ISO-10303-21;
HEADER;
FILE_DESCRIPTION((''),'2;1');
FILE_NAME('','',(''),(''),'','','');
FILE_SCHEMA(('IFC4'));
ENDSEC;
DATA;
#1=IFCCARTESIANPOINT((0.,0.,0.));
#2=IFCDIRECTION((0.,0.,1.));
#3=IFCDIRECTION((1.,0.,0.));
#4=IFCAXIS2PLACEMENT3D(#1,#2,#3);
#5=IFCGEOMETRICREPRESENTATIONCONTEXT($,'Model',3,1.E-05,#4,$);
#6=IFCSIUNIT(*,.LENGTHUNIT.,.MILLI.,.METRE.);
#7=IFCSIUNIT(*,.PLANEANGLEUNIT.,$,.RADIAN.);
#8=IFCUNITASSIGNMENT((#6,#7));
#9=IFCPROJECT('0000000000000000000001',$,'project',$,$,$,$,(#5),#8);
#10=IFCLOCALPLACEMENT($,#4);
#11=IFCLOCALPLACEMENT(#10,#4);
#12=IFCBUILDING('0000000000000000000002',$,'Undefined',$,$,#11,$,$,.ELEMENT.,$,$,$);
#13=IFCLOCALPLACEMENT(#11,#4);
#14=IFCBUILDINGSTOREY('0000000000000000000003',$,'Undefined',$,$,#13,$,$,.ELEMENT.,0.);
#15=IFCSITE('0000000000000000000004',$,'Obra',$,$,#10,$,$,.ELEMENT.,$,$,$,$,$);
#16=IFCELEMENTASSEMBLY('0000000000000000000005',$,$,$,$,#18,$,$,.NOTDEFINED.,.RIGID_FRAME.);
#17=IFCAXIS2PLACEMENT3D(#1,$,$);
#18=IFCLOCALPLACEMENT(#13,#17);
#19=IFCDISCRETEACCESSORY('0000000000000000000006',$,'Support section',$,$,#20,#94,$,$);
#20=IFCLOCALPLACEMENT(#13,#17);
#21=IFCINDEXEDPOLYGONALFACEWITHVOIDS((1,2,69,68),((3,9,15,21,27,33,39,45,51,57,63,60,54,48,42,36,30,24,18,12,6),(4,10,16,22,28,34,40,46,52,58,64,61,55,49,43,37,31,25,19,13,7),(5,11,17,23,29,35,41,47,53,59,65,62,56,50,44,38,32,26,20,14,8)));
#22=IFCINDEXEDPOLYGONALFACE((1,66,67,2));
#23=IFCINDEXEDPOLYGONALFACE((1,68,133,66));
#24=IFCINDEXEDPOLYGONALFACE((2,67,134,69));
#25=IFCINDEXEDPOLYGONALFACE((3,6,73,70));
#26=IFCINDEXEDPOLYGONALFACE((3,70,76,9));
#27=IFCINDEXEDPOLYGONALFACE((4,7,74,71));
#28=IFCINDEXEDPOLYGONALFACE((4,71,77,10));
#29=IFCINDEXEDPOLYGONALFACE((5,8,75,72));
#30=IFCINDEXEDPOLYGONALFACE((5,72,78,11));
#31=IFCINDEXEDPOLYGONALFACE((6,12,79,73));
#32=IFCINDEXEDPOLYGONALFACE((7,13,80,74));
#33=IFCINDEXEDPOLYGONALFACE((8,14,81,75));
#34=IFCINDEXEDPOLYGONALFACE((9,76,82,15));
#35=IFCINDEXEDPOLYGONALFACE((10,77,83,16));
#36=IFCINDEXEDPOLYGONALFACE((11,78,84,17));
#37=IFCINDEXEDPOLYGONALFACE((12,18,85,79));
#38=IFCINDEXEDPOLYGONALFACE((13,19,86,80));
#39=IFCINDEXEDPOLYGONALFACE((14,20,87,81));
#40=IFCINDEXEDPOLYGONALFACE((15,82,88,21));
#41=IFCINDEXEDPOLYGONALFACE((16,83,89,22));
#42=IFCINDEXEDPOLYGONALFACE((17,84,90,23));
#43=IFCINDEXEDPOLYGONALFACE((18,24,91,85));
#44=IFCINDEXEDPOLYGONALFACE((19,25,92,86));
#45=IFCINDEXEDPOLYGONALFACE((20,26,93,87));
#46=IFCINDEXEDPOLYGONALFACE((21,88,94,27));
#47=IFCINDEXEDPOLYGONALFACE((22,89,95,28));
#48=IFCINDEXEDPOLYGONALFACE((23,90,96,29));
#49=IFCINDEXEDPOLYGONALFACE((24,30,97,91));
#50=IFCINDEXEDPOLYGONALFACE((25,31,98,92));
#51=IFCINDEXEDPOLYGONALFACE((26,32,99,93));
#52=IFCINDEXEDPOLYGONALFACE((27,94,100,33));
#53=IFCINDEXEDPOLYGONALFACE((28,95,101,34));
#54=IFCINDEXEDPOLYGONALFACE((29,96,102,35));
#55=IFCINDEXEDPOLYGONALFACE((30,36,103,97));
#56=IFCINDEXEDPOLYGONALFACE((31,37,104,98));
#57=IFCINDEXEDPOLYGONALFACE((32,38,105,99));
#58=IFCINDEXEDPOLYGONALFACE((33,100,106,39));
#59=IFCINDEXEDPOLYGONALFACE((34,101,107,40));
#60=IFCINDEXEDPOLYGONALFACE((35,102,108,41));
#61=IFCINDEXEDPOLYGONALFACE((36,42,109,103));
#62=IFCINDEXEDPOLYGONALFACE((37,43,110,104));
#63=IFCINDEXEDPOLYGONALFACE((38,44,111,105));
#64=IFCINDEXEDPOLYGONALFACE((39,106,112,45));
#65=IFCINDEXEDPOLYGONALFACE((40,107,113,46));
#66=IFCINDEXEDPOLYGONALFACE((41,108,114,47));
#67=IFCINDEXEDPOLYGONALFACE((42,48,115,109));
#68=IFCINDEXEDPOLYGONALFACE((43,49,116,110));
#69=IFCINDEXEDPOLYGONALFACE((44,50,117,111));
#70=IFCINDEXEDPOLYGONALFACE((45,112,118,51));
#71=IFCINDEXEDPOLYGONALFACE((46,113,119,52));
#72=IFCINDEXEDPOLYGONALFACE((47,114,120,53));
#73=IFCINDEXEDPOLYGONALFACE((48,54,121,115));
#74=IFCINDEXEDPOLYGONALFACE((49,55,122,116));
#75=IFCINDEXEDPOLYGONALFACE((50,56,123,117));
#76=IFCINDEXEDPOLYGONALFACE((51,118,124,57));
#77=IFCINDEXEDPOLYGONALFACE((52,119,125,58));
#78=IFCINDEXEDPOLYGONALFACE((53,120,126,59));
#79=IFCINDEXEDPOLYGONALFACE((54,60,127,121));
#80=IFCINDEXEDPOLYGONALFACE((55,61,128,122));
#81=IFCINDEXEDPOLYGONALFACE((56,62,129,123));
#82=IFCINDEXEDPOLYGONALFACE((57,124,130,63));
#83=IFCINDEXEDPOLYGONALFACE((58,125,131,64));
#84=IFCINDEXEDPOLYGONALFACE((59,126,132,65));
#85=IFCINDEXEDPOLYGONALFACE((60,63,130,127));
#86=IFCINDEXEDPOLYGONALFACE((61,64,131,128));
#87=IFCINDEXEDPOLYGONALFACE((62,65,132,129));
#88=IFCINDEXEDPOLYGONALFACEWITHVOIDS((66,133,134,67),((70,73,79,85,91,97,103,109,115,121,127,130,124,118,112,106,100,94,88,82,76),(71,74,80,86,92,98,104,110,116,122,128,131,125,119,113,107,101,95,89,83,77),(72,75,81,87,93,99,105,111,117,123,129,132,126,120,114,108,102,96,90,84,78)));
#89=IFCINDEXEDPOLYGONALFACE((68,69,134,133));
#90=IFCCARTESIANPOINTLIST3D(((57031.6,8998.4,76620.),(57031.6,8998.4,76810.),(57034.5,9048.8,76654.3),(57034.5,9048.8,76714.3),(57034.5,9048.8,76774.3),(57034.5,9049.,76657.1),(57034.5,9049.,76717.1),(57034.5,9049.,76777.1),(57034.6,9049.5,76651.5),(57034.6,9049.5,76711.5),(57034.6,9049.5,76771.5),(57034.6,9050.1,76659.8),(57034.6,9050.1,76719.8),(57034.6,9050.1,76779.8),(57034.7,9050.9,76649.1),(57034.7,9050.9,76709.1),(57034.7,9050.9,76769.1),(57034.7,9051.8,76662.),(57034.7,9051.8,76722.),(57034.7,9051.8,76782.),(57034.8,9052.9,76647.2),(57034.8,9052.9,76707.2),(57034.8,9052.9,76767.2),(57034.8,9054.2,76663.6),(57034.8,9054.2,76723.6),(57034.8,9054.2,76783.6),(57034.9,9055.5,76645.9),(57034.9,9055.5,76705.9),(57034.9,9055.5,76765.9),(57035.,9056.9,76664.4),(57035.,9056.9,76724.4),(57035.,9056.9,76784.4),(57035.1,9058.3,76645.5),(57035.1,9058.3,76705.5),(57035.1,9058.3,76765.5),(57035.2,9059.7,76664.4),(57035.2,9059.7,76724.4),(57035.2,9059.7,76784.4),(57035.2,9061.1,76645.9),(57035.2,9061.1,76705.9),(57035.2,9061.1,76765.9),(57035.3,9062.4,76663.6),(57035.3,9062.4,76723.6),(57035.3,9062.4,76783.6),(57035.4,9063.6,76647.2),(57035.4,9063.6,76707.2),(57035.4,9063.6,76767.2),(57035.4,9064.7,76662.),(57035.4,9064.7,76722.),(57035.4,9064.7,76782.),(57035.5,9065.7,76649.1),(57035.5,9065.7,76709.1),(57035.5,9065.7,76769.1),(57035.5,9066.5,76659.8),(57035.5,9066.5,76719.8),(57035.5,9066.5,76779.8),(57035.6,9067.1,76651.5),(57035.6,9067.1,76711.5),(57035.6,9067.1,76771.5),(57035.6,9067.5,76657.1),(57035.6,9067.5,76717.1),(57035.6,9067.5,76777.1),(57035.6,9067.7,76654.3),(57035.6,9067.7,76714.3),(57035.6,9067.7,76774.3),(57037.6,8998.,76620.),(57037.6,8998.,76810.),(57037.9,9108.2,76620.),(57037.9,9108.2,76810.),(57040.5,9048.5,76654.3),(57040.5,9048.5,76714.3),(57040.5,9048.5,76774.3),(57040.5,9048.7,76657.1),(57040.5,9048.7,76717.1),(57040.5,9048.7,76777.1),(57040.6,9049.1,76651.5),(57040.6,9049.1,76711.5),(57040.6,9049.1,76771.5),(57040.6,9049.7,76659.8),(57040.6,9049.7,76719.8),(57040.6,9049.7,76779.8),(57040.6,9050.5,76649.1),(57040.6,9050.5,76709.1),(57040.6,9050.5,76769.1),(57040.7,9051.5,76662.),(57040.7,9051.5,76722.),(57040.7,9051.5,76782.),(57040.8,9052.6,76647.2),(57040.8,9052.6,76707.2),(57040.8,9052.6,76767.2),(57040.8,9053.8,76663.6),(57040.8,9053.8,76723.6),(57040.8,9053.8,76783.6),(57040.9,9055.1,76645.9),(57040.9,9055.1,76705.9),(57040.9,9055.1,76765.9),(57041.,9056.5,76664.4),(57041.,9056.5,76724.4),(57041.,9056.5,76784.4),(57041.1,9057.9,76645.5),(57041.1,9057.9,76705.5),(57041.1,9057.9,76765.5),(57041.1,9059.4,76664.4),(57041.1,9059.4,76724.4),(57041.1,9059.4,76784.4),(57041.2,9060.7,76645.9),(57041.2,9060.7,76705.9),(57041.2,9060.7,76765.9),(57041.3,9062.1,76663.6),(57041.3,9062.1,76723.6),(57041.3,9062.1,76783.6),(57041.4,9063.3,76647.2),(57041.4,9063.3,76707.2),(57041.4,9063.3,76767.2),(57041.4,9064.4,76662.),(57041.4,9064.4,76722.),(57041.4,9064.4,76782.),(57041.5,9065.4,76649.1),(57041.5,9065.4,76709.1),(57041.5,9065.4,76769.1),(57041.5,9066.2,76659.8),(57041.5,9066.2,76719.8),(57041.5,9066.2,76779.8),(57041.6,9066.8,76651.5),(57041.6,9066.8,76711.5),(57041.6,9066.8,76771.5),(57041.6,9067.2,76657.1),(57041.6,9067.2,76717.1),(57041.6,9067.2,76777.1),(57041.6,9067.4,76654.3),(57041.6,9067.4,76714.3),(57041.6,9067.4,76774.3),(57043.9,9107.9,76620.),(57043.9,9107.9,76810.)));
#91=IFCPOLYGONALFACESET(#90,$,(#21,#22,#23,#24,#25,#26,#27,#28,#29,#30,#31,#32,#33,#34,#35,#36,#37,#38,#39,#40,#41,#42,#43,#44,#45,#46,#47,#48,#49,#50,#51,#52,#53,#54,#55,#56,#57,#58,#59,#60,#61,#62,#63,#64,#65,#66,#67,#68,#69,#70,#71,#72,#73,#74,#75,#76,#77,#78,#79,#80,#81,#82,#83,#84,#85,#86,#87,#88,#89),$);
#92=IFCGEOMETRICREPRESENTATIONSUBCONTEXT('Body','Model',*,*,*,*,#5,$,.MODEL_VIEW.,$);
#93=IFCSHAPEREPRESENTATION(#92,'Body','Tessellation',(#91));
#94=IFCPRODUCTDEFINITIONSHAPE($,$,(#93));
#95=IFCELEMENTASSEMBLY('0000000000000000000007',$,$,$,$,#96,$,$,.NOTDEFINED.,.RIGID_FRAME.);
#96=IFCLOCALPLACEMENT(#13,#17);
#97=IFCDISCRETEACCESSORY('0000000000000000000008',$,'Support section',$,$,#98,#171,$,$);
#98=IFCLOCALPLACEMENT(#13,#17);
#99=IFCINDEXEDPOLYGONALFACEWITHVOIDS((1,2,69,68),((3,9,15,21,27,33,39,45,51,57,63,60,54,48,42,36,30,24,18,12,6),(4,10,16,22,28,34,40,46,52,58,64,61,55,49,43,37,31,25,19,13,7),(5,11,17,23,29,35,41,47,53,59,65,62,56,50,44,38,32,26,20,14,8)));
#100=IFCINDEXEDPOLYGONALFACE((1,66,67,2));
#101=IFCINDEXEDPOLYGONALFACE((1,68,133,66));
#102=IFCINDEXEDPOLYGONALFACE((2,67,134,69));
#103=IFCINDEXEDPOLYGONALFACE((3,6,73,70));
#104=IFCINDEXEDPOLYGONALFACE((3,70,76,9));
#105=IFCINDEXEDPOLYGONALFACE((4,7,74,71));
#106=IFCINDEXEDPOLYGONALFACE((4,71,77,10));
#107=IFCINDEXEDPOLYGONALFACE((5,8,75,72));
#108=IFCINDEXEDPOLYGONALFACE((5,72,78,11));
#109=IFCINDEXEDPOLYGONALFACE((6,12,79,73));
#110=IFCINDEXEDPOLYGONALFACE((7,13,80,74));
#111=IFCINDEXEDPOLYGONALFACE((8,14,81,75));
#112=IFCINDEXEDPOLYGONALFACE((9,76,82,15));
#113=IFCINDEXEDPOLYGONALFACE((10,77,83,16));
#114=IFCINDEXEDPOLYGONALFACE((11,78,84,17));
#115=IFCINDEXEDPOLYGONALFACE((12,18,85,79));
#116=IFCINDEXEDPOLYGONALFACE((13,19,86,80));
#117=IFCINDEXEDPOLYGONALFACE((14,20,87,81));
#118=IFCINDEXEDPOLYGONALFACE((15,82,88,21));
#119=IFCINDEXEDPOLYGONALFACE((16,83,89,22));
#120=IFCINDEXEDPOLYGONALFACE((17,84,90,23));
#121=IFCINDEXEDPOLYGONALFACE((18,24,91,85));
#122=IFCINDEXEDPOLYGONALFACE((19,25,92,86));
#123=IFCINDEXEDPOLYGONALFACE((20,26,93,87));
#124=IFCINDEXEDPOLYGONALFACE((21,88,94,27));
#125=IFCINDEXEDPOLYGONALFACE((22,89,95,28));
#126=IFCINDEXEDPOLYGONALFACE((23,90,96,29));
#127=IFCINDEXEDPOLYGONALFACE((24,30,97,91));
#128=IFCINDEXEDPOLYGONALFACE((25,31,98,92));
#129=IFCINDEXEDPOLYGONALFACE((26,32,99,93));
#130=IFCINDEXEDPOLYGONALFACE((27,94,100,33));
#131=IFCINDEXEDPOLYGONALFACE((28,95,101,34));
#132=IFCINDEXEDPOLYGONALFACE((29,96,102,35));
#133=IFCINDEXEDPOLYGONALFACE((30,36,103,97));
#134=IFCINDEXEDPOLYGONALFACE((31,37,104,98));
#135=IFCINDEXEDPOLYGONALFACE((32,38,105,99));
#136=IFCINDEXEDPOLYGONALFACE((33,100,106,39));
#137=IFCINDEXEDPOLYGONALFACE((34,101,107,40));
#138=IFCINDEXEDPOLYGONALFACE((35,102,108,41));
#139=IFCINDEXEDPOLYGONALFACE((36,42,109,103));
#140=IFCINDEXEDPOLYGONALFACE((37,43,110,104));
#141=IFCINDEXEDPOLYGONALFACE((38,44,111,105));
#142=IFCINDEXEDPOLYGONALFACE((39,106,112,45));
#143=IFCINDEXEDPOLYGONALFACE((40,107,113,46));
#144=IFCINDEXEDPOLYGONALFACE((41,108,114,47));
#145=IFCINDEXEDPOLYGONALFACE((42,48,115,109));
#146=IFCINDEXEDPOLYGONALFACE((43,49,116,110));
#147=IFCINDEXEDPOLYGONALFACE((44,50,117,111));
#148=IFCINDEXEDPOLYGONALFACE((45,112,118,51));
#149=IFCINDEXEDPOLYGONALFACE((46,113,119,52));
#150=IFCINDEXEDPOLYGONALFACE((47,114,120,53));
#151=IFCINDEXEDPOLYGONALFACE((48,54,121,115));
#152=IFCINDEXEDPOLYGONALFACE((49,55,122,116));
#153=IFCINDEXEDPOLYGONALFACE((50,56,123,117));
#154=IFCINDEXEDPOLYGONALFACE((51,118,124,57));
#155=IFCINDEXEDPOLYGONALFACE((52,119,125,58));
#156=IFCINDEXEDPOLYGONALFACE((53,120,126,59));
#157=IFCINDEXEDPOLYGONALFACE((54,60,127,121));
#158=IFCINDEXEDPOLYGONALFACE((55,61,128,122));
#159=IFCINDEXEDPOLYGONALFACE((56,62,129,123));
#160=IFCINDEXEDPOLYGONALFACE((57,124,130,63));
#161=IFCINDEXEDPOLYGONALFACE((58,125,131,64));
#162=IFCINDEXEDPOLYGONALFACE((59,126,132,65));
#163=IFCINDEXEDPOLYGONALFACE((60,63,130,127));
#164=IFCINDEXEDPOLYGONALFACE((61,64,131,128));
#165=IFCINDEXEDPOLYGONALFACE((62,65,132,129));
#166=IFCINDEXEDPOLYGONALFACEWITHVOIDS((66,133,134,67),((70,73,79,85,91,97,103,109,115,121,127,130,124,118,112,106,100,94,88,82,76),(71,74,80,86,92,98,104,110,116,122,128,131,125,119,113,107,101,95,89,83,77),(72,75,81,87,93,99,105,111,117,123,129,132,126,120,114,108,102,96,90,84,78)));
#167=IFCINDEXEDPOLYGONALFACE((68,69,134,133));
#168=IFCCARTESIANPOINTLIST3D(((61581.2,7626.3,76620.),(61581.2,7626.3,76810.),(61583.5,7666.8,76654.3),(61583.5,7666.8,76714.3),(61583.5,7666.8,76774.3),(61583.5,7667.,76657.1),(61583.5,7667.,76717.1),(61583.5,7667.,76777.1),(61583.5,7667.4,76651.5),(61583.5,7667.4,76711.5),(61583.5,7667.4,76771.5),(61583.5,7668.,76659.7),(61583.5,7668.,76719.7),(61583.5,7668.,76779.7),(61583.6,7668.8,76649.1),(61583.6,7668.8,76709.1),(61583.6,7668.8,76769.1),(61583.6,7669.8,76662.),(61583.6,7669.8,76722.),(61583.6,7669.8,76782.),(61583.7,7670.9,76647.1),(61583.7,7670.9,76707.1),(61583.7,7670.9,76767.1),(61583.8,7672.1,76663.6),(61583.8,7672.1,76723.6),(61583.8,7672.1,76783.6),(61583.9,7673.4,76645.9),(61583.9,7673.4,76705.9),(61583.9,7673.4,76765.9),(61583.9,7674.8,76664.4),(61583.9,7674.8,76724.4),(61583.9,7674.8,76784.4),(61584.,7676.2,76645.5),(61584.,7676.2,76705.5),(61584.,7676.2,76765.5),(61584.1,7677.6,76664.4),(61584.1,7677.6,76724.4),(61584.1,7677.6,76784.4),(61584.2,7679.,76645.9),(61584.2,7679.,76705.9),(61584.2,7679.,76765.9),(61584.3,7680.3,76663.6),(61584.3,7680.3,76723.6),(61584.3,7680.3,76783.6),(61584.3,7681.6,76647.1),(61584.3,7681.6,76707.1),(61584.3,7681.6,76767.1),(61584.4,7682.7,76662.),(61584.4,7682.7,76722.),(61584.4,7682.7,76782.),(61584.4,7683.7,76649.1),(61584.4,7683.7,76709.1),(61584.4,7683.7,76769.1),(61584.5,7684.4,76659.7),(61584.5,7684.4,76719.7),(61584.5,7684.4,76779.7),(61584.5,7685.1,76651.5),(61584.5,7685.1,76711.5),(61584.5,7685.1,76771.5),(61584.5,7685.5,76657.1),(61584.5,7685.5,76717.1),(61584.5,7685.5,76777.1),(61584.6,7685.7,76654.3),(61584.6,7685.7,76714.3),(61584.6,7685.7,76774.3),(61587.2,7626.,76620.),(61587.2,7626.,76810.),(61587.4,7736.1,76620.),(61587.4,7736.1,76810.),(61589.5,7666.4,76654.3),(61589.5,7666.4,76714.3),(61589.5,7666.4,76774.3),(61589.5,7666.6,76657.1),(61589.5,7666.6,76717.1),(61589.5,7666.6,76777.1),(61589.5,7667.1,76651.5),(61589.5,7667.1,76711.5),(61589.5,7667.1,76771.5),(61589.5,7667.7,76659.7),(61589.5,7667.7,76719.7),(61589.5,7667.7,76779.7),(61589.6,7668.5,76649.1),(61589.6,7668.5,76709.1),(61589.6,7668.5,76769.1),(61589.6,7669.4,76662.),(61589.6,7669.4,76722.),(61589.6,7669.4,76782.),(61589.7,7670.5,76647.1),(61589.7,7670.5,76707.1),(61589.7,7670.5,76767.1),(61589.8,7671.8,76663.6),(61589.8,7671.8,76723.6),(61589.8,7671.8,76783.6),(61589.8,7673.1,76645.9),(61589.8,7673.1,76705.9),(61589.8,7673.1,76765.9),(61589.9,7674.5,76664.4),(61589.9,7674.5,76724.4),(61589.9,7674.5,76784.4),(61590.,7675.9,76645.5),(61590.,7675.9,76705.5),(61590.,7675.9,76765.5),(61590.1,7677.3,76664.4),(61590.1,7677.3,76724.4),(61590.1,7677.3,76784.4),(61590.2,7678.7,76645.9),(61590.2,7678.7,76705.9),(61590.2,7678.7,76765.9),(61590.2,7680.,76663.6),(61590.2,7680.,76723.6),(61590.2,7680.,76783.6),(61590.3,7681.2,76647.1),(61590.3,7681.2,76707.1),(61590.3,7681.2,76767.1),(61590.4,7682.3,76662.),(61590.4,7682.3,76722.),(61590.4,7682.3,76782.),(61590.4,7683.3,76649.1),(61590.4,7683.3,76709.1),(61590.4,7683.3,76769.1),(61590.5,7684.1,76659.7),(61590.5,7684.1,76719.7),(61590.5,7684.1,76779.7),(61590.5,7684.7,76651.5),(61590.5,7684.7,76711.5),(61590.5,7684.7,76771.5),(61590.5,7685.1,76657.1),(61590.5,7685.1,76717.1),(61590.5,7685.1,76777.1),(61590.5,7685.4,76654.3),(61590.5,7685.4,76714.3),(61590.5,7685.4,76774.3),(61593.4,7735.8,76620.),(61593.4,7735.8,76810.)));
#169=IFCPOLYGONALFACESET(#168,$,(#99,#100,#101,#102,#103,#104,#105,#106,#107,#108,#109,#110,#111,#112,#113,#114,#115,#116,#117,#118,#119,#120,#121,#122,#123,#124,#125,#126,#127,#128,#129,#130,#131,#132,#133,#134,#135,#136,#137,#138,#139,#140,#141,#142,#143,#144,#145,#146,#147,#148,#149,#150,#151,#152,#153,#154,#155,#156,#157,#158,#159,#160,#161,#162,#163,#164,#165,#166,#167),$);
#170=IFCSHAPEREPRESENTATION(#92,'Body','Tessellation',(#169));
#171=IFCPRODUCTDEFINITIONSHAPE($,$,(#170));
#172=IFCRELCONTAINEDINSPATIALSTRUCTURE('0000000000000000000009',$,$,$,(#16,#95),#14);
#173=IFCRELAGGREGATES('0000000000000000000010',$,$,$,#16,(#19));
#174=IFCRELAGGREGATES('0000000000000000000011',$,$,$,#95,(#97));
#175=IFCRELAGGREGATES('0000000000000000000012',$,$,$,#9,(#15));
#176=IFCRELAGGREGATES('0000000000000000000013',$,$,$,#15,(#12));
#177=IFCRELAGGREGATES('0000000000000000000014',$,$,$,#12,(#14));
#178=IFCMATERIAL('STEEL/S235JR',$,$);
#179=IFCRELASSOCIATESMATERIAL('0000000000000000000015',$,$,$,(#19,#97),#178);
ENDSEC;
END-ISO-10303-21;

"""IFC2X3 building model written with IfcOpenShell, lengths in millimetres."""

from ifc_helpers import new_model, si_unit, frame, origin_with_axes, origin_2d_with_axis, place, context, subcontext, project, spatial, rectangle, circle, extrude, source, transform, mapped, material, element, aggregate, save


model = new_model("IFC2X3")

# Units and contexts
model_context = context("Model", 3, precision=1e-05, world=origin_with_axes())
body_context = subcontext(model_context, "Body", "Model", "MODEL_VIEW")
ifc_project = project(units=[si_unit("LENGTHUNIT", "METRE", prefix="MILLI"), si_unit("PLANEANGLEUNIT", "RADIAN")], contexts=[model_context])

# Site, building, storey
site_placement = place(None, origin_with_axes())
site = spatial("IfcSite", under=ifc_project, at=site_placement, Name="Obra", CompositionType="ELEMENT")
building_placement = place(site_placement, origin_with_axes())
building = spatial("IfcBuilding", under=site, at=building_placement, Name="Undefined", CompositionType="ELEMENT")
storey_placement = place(building_placement, origin_with_axes())
storey = spatial("IfcBuildingStorey", under=building, at=storey_placement, Name="Undefined", CompositionType="ELEMENT", Elevation=0.0)

# Element assembly
assembly_1_placement = place(storey_placement, origin_with_axes())
assembly_1 = element("IfcElementAssembly", 1, at=assembly_1_placement, inside=storey, AssemblyPlace="NOTDEFINED", PredefinedType="RIGID_FRAME")
ifc_material_1 = material(Name="STEEL/S235JR")

# Discrete accessory, opening
discrete_accessory_1_placement = place(assembly_1_placement, frame((57037.8, 9053.1, 76620.0), z_axis=(0.0, 0.0, 1.0), x_axis=(-0.05711, -0.998368, 0.0)))
discrete_accessory_1 = element("IfcDiscreteAccessory", 2, at=discrete_accessory_1_placement, material=ifc_material_1, Name="Support section", context=body_context, shape_type="SweptSolid", body=[
    extrude(rectangle(XDim=6.0, YDim=110.0, at=origin_2d_with_axis()), frame((0.0, 0.0, 190.0), z_axis=(0.0, 0.0, -1.0), x_axis=(0.0, 1.0, 0.0)), (0.0, 0.0, 1.0), 190.0),
])
shared_shape_1 = source(origin_with_axes(), body_context, "Body", "SweptSolid", [
    extrude(circle(Radius=9.5, at=origin_2d_with_axis()), frame((0.0, -9.2, 0.0), z_axis=(0.0, 1.0, 0.0), x_axis=(1.0, 0.0, 0.0)), (0.0, 0.0, 1.0), 6.2),
])
opening_1_placement = place(assembly_1_placement, frame((57029.1, 9008.5, 76835.0), z_axis=(0.05711, 0.998368, 0.0), x_axis=(0.0, 0.0, -1.0)))
element("IfcOpeningElement", 3, at=opening_1_placement, cuts=discrete_accessory_1, ObjectType="Opening", context=body_context, shape_type="MappedRepresentation", body=[
    mapped(shared_shape_1, transform((60.0, 0.0, 50.0))),
    mapped(shared_shape_1, transform((120.0, 0.0, 50.0))),
    mapped(shared_shape_1, transform((180.0, 0.0, 50.0))),
])
aggregate(assembly_1, [discrete_accessory_1])

# Element assembly, discrete accessory, opening
assembly_2_placement = place(storey_placement, origin_with_axes())
assembly_2 = element("IfcElementAssembly", 4, at=assembly_2_placement, inside=storey, AssemblyPlace="NOTDEFINED", PredefinedType="RIGID_FRAME")
discrete_accessory_2_placement = place(assembly_2_placement, frame((61587.3, 7681.1, 76620.0), z_axis=(0.0, 0.0, 1.0), x_axis=(0.05711, 0.998368, 0.0)))
discrete_accessory_2 = element("IfcDiscreteAccessory", 5, at=discrete_accessory_2_placement, material=ifc_material_1, Name="Support section", context=body_context, shape_type="SweptSolid", body=[
    extrude(rectangle(XDim=6.0, YDim=110.0, at=origin_2d_with_axis()), frame((0.0, 0.0, 190.0), z_axis=(0.0, 0.0, -1.0), x_axis=(0.0, 1.0, 0.0)), (0.0, 0.0, 1.0), 190.0),
])
opening_2_placement = place(assembly_2_placement, frame((61596.0, 7725.6, 76835.0), z_axis=(-0.05711, -0.998368, 0.0), x_axis=(0.0, 0.0, -1.0)))
element("IfcOpeningElement", 6, at=opening_2_placement, cuts=discrete_accessory_2, ObjectType="Opening", context=body_context, shape_type="MappedRepresentation", body=[
    mapped(shared_shape_1, transform((60.0, 0.0, 50.0))),
    mapped(shared_shape_1, transform((120.0, 0.0, 50.0))),
    mapped(shared_shape_1, transform((180.0, 0.0, 50.0))),
])
aggregate(assembly_2, [discrete_accessory_2])

save(model, "model.ifc")
